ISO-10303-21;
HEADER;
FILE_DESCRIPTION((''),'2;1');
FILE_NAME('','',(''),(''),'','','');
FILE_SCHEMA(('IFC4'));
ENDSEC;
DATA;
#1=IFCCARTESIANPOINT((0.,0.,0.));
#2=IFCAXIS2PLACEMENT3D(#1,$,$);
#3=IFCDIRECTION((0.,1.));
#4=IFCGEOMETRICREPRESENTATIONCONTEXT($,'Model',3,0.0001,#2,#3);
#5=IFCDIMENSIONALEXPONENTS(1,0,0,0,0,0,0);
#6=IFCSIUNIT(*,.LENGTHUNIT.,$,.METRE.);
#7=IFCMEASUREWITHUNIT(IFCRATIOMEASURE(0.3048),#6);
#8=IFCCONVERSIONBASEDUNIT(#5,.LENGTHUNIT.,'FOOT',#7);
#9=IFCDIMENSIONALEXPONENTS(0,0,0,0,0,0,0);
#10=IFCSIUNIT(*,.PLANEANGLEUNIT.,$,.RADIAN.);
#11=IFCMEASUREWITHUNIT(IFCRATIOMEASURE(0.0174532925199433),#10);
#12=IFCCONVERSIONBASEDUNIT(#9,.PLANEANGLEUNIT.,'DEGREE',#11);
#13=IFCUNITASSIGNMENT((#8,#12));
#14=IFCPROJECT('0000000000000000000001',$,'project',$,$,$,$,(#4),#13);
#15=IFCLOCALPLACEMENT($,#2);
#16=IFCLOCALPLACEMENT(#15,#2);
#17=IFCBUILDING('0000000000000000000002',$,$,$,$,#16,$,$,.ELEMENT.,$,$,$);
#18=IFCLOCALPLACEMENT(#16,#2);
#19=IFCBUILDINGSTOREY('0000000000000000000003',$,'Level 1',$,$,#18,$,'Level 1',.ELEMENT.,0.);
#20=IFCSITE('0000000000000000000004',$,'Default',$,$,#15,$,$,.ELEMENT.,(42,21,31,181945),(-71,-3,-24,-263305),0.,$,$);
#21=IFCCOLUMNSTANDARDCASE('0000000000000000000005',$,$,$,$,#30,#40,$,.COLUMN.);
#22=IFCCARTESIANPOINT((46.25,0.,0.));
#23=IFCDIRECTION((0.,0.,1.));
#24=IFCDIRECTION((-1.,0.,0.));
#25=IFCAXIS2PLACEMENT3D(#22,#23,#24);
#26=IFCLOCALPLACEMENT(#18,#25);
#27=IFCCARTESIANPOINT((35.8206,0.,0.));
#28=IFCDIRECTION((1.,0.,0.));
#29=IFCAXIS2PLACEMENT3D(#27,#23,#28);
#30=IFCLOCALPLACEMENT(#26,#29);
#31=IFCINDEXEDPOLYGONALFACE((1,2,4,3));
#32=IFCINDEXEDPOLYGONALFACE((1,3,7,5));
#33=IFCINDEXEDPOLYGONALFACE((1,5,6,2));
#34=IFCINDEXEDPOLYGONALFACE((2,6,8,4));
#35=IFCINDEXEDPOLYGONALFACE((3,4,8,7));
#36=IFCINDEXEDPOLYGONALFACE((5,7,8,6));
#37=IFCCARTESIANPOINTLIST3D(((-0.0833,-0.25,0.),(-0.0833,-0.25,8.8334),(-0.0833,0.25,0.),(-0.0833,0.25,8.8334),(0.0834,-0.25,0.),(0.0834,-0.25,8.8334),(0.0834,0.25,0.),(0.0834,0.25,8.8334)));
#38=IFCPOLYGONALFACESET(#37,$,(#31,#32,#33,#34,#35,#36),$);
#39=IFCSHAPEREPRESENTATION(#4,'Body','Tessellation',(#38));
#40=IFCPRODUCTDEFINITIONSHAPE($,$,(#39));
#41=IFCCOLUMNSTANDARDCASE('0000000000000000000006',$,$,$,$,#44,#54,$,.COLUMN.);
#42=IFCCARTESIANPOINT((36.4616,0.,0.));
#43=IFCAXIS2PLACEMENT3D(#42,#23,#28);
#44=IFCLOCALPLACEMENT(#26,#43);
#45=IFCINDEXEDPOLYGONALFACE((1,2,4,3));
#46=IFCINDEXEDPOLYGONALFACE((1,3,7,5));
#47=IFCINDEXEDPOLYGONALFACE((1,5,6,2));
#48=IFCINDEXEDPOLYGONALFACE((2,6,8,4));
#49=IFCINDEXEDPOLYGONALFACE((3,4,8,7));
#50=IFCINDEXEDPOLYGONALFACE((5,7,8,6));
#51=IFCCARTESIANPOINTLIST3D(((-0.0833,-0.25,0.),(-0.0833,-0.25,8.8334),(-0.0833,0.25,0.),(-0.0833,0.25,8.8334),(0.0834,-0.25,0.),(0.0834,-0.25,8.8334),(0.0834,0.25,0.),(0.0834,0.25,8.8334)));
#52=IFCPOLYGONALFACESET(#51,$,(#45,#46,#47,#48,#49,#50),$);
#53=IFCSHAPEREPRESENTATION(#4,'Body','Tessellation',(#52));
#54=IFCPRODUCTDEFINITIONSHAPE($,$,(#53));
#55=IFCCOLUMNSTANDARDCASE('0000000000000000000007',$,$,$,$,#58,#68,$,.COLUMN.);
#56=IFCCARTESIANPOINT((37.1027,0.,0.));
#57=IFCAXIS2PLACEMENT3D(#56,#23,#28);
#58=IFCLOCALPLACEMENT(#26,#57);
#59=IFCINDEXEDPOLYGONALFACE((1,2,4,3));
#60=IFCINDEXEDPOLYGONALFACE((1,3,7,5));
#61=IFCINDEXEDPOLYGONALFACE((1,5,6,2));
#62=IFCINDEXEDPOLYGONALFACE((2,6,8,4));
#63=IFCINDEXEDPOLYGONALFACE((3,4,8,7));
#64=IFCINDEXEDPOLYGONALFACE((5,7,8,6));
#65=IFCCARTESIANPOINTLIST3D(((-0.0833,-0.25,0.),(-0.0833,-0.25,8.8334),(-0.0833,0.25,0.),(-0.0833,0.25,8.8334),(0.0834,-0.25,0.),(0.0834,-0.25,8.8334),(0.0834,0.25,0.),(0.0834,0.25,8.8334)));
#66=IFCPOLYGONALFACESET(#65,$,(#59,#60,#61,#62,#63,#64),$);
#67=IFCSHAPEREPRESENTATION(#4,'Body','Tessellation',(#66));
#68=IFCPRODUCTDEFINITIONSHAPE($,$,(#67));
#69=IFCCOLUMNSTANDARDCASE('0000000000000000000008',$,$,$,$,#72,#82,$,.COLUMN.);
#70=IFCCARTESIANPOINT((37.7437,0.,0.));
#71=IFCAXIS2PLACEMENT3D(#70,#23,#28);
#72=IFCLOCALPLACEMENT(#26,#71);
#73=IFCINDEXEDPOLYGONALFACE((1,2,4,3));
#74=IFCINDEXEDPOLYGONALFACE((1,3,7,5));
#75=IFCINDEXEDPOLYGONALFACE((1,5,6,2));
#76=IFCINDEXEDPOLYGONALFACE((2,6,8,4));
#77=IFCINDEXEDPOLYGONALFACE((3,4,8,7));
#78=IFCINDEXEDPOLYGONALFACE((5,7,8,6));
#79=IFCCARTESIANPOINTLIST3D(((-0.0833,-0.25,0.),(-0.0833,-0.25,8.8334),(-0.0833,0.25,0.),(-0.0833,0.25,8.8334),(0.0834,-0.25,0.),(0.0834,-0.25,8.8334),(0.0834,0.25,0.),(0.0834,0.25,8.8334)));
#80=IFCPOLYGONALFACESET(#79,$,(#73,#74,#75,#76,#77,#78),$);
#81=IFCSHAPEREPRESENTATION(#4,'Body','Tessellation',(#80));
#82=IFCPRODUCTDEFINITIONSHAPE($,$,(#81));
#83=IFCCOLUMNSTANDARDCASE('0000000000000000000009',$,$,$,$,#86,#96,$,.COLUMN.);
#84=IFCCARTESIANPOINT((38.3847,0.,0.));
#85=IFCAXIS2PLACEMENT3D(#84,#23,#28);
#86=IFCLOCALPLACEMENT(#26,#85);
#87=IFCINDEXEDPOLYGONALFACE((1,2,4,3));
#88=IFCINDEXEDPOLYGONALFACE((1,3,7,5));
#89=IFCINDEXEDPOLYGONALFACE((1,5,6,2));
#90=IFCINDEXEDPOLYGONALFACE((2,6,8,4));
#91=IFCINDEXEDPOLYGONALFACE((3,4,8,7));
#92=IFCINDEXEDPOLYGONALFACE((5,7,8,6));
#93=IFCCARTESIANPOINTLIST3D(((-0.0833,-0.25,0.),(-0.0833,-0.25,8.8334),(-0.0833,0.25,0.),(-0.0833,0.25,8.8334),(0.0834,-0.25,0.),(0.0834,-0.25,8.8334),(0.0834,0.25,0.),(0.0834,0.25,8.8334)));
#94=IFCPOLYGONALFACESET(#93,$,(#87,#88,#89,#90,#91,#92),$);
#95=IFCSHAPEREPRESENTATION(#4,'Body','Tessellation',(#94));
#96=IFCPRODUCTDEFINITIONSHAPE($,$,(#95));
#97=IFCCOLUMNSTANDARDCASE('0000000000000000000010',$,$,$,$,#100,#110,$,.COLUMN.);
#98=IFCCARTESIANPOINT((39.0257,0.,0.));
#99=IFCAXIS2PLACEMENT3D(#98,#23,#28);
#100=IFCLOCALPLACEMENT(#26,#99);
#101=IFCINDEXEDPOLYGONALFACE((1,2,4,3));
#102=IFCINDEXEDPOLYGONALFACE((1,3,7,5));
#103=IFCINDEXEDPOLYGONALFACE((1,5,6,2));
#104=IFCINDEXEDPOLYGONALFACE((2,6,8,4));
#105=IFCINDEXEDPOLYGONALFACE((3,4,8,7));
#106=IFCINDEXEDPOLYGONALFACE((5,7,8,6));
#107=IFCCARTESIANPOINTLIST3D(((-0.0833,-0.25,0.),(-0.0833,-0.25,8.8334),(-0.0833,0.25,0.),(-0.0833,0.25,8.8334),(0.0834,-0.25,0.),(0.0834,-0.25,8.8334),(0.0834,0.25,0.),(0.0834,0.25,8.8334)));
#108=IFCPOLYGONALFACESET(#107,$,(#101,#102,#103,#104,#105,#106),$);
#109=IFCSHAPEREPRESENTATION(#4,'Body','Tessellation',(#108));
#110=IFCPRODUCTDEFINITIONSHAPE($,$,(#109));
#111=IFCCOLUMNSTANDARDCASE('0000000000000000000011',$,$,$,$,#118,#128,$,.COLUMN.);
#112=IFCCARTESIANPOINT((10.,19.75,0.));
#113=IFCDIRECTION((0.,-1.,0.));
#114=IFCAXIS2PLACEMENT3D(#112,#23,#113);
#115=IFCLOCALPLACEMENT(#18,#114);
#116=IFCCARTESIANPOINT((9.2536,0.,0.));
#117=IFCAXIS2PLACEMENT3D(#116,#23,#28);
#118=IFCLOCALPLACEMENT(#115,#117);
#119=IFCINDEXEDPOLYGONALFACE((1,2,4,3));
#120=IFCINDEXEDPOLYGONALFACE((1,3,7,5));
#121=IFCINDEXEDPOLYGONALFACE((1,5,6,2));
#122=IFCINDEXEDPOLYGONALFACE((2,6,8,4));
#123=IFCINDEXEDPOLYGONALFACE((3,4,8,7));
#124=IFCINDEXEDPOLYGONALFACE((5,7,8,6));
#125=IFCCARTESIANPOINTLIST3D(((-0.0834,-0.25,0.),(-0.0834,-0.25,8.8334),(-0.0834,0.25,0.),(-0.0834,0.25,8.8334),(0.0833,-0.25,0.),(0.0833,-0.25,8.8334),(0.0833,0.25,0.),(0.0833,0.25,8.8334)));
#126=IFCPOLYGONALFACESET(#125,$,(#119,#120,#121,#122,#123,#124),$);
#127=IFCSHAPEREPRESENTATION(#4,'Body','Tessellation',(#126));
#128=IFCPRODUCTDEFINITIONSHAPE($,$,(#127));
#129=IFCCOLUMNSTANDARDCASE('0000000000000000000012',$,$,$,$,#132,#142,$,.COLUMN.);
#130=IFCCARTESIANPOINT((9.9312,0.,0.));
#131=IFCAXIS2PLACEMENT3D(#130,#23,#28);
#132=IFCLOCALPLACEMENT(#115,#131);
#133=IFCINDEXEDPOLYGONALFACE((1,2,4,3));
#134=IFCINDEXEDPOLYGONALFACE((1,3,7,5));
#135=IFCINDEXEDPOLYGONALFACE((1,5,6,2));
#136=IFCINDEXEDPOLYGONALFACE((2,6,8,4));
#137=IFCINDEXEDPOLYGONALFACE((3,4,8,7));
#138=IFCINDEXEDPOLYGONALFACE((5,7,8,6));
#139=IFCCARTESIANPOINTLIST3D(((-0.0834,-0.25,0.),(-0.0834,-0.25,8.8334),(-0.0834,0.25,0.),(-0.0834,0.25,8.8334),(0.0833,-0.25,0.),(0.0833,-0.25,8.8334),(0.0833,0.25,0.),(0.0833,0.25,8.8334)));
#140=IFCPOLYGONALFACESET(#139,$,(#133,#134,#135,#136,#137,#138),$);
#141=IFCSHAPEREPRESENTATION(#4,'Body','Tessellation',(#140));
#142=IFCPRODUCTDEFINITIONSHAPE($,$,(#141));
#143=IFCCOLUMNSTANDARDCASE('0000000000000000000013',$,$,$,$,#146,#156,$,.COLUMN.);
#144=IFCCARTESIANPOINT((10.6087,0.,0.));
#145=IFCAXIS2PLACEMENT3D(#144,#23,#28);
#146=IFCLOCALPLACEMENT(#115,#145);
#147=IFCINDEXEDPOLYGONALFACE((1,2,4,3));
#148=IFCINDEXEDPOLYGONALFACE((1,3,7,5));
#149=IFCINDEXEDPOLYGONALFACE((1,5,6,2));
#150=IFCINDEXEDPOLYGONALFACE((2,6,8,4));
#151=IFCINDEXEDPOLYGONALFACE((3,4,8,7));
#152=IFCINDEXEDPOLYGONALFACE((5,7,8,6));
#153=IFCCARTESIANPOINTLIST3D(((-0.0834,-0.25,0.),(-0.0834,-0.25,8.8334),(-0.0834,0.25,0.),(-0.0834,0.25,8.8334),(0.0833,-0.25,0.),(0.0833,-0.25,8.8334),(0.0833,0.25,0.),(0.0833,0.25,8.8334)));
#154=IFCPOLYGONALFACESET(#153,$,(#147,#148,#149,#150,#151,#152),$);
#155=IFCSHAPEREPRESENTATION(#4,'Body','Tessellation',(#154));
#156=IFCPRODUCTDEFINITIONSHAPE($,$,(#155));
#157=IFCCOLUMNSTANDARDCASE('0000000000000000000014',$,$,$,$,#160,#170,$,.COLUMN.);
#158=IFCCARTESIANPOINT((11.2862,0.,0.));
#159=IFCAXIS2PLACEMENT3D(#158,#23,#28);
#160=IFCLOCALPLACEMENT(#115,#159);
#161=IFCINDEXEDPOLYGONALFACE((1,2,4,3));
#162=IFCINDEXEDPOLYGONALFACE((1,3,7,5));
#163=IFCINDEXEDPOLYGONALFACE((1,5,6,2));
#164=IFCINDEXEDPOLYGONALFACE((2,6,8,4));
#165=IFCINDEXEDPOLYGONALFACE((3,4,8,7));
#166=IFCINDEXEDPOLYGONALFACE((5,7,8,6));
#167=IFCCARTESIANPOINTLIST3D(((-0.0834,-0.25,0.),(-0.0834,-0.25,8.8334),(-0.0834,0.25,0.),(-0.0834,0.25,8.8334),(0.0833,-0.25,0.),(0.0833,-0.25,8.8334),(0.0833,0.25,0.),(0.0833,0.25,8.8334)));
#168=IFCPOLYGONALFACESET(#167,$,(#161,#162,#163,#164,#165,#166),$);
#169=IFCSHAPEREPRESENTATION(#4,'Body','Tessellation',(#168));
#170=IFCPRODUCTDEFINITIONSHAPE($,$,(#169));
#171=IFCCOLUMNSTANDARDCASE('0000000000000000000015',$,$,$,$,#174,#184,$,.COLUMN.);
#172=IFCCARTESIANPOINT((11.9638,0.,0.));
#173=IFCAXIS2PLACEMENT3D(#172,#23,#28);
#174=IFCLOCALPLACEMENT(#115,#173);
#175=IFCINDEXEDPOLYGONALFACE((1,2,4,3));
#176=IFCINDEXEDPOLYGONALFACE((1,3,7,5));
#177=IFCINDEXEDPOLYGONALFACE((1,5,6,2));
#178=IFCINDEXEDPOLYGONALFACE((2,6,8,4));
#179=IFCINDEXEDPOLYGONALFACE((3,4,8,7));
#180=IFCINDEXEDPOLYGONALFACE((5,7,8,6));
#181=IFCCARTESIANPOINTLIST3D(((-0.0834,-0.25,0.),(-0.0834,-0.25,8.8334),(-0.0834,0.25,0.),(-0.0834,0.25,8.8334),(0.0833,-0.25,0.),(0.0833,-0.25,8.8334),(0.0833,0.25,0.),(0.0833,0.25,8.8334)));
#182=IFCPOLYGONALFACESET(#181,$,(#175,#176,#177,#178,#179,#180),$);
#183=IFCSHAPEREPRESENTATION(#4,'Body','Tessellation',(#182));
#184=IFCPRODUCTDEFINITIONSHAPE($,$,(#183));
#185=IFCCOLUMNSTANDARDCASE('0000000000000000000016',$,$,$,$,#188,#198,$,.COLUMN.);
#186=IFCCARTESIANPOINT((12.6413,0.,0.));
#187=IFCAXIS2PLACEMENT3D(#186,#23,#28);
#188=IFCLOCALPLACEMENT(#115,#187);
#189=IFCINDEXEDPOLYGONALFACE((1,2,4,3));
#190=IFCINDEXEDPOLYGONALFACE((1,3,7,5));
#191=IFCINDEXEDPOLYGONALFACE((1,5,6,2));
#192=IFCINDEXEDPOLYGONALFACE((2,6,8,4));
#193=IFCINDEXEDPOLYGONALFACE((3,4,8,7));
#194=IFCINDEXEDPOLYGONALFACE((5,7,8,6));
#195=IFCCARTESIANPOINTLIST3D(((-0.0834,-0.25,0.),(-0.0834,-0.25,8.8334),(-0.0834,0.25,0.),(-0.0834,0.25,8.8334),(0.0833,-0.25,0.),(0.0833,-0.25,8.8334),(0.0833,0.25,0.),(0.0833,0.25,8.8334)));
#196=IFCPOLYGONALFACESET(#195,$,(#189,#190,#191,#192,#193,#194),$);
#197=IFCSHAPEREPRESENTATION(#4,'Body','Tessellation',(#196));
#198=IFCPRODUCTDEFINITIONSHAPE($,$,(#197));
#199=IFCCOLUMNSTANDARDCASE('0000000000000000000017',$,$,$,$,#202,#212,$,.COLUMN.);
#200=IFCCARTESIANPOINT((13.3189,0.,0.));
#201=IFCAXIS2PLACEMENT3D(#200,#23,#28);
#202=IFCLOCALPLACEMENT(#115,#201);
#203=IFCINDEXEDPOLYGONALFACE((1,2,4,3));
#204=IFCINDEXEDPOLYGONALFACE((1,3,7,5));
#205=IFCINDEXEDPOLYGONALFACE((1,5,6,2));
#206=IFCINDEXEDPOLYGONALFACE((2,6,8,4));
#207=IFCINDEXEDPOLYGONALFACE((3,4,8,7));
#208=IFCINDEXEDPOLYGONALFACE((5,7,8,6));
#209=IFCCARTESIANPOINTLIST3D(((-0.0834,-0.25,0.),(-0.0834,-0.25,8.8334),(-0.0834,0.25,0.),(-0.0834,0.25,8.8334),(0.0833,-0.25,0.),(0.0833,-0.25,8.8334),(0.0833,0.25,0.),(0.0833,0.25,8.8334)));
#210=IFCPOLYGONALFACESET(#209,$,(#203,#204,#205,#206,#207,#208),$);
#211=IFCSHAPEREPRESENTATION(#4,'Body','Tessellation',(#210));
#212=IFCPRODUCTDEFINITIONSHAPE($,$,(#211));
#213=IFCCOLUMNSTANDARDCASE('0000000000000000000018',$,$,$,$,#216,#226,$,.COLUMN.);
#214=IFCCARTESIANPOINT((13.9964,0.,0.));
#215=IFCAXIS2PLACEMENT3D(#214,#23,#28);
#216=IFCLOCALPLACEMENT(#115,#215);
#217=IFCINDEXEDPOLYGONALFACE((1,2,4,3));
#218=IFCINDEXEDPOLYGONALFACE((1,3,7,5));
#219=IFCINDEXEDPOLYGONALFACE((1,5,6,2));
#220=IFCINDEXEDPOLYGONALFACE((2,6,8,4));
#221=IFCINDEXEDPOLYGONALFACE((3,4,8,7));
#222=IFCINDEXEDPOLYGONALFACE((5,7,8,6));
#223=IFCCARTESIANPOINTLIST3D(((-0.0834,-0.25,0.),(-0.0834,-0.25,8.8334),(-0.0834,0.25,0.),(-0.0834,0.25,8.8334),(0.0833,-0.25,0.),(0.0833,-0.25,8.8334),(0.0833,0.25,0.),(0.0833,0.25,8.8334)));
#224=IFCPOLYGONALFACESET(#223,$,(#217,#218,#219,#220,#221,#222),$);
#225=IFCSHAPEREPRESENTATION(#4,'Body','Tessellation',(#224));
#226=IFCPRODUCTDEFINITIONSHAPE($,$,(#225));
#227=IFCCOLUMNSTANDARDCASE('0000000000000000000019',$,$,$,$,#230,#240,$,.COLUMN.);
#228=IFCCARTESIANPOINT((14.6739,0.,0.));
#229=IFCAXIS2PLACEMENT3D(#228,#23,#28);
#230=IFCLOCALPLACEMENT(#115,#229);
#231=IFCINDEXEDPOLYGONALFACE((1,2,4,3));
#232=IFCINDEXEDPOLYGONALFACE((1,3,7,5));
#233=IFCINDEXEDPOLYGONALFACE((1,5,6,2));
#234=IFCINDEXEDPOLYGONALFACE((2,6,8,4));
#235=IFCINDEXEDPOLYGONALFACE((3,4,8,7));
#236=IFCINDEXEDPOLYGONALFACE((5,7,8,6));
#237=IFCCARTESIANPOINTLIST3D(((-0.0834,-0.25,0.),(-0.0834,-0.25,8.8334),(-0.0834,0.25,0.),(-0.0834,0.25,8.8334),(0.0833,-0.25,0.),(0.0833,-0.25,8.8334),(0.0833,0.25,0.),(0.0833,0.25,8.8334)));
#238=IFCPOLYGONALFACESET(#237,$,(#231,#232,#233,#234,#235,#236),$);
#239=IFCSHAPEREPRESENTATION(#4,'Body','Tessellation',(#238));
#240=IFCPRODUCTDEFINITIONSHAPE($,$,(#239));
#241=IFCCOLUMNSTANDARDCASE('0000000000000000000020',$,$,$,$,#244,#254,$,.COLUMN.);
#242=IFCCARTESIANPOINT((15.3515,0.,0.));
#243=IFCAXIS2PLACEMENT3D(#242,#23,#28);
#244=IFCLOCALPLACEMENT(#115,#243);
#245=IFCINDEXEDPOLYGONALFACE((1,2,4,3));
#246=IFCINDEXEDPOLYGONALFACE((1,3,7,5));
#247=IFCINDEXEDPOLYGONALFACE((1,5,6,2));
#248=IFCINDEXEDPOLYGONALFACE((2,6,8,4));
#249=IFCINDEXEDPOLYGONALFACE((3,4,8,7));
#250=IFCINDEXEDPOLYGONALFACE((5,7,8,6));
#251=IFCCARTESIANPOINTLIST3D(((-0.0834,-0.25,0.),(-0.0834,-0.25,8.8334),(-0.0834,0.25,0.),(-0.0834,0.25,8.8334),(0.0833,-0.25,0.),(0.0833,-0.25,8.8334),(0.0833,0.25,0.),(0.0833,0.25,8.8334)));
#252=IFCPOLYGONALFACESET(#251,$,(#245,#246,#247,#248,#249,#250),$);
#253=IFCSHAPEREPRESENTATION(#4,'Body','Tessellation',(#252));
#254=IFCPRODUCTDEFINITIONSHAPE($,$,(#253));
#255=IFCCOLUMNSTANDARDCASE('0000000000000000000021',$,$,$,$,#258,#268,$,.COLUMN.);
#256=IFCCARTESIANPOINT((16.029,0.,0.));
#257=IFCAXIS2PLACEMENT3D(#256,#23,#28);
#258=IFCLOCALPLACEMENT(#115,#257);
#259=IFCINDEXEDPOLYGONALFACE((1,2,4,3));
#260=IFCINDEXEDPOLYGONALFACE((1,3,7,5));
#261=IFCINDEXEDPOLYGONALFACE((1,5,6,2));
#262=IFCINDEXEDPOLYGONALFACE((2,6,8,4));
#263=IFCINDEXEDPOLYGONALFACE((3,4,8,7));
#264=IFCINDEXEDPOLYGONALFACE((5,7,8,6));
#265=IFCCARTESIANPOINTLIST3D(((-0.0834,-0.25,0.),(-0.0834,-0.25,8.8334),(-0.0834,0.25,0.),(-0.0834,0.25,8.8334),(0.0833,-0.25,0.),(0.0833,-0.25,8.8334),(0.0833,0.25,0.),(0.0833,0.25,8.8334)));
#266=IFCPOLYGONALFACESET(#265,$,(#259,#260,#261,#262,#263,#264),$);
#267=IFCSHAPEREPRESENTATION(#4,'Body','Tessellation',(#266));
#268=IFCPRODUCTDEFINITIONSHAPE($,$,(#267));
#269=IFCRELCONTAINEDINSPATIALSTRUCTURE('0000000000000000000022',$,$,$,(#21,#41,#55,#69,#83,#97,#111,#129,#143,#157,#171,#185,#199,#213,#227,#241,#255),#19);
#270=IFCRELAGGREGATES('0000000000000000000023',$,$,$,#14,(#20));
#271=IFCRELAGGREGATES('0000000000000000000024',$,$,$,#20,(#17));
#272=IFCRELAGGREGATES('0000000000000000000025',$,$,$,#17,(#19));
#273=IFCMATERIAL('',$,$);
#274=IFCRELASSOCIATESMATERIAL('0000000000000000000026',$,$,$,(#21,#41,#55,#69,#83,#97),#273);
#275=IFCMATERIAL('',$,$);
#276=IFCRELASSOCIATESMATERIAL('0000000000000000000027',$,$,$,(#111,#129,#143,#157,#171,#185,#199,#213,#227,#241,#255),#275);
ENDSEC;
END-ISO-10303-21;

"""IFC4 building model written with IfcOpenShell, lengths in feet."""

from ifc_helpers import new_model, entity, si_unit, converted_unit, direction, frame, origin, place, context, project, spatial, rectangle, extrude, material, element, save


model = new_model("IFC4")

# Units and contexts
model_context = context("Model", 3, precision=0.0001, world=origin(), true_north=direction((0.0, 1.0)))
ifc_project = project(units=[converted_unit("LENGTHUNIT", "FOOT", entity("IfcRatioMeasure", 0.3048), si_unit("LENGTHUNIT", "METRE"), dimensions=[1, 0, 0, 0, 0, 0, 0]), converted_unit("PLANEANGLEUNIT", "DEGREE", entity("IfcRatioMeasure", 0.0174532925199433), si_unit("PLANEANGLEUNIT", "RADIAN"), dimensions=[0, 0, 0, 0, 0, 0, 0])], contexts=[model_context])

# Site, building, storey
site_placement = place(None, origin())
site = spatial("IfcSite", under=ifc_project, at=site_placement, Name="Default", CompositionType="ELEMENT", RefLatitude=(42, 21, 31, 181945), RefLongitude=(-71, -3, -24, -263305), RefElevation=0.0)
building_placement = place(site_placement, origin())
building = spatial("IfcBuilding", under=site, at=building_placement, CompositionType="ELEMENT")
storey_placement = place(building_placement, origin())
storey = spatial("IfcBuildingStorey", under=building, at=storey_placement, Name="Level 1", LongName="Level 1", CompositionType="ELEMENT", Elevation=0.0)

# Columns
ifc_material_1 = material(Name="")
placement_1 = place(storey_placement, frame((46.25, 0.0, 0.0), z_axis=(0.0, 0.0, 1.0), x_axis=(-1.0, 0.0, 0.0)))
for number, where, z_axis, x_axis in (
    (1, (35.8206, 0.0, 0.0), (0.0, 0.0, 1.0), (1.0, 0.0, 0.0)),
    (2, (36.4616, 0.0, 0.0), (0.0, 0.0, 1.0), (1.0, 0.0, 0.0)),
    (3, (37.1027, 0.0, 0.0), (0.0, 0.0, 1.0), (1.0, 0.0, 0.0)),
    (4, (37.7437, 0.0, 0.0), (0.0, 0.0, 1.0), (1.0, 0.0, 0.0)),
    (5, (38.3847, 0.0, 0.0), (0.0, 0.0, 1.0), (1.0, 0.0, 0.0)),
    (6, (39.0257, 0.0, 0.0), (0.0, 0.0, 1.0), (1.0, 0.0, 0.0)),
):
    element("IfcColumnStandardCase", number, at=place(placement_1, frame(where, z_axis=z_axis, x_axis=x_axis)), inside=storey, material=ifc_material_1, PredefinedType="COLUMN", context=model_context, shape_type="SweptSolid", body=[
        extrude(rectangle(XDim=0.1667, YDim=0.5), origin(), (0.0, 0.0, 1.0), 8.8334),
    ])
ifc_material_2 = material(Name="")
placement_2 = place(storey_placement, frame((10.0, 19.75, 0.0), z_axis=(0.0, 0.0, 1.0), x_axis=(0.0, -1.0, 0.0)))
for number, where, z_axis, x_axis in (
    (7, (9.2536, 0.0, 0.0), (0.0, 0.0, 1.0), (1.0, 0.0, 0.0)),
    (8, (9.9312, 0.0, 0.0), (0.0, 0.0, 1.0), (1.0, 0.0, 0.0)),
    (9, (10.6087, 0.0, 0.0), (0.0, 0.0, 1.0), (1.0, 0.0, 0.0)),
    (10, (11.2862, 0.0, 0.0), (0.0, 0.0, 1.0), (1.0, 0.0, 0.0)),
    (11, (11.9638, 0.0, 0.0), (0.0, 0.0, 1.0), (1.0, 0.0, 0.0)),
    (12, (12.6413, 0.0, 0.0), (0.0, 0.0, 1.0), (1.0, 0.0, 0.0)),
    (13, (13.3189, 0.0, 0.0), (0.0, 0.0, 1.0), (1.0, 0.0, 0.0)),
    (14, (13.9964, 0.0, 0.0), (0.0, 0.0, 1.0), (1.0, 0.0, 0.0)),
    (15, (14.6739, 0.0, 0.0), (0.0, 0.0, 1.0), (1.0, 0.0, 0.0)),
    (16, (15.3515, 0.0, 0.0), (0.0, 0.0, 1.0), (1.0, 0.0, 0.0)),
    (17, (16.029, 0.0, 0.0), (0.0, 0.0, 1.0), (1.0, 0.0, 0.0)),
):
    element("IfcColumnStandardCase", number, at=place(placement_2, frame(where, z_axis=z_axis, x_axis=x_axis)), inside=storey, material=ifc_material_2, PredefinedType="COLUMN", context=model_context, shape_type="SweptSolid", body=[
        extrude(rectangle(XDim=0.1667, YDim=0.5), origin(), (0.0, 0.0, 1.0), 8.8334),
    ])

save(model, "model.ifc")
